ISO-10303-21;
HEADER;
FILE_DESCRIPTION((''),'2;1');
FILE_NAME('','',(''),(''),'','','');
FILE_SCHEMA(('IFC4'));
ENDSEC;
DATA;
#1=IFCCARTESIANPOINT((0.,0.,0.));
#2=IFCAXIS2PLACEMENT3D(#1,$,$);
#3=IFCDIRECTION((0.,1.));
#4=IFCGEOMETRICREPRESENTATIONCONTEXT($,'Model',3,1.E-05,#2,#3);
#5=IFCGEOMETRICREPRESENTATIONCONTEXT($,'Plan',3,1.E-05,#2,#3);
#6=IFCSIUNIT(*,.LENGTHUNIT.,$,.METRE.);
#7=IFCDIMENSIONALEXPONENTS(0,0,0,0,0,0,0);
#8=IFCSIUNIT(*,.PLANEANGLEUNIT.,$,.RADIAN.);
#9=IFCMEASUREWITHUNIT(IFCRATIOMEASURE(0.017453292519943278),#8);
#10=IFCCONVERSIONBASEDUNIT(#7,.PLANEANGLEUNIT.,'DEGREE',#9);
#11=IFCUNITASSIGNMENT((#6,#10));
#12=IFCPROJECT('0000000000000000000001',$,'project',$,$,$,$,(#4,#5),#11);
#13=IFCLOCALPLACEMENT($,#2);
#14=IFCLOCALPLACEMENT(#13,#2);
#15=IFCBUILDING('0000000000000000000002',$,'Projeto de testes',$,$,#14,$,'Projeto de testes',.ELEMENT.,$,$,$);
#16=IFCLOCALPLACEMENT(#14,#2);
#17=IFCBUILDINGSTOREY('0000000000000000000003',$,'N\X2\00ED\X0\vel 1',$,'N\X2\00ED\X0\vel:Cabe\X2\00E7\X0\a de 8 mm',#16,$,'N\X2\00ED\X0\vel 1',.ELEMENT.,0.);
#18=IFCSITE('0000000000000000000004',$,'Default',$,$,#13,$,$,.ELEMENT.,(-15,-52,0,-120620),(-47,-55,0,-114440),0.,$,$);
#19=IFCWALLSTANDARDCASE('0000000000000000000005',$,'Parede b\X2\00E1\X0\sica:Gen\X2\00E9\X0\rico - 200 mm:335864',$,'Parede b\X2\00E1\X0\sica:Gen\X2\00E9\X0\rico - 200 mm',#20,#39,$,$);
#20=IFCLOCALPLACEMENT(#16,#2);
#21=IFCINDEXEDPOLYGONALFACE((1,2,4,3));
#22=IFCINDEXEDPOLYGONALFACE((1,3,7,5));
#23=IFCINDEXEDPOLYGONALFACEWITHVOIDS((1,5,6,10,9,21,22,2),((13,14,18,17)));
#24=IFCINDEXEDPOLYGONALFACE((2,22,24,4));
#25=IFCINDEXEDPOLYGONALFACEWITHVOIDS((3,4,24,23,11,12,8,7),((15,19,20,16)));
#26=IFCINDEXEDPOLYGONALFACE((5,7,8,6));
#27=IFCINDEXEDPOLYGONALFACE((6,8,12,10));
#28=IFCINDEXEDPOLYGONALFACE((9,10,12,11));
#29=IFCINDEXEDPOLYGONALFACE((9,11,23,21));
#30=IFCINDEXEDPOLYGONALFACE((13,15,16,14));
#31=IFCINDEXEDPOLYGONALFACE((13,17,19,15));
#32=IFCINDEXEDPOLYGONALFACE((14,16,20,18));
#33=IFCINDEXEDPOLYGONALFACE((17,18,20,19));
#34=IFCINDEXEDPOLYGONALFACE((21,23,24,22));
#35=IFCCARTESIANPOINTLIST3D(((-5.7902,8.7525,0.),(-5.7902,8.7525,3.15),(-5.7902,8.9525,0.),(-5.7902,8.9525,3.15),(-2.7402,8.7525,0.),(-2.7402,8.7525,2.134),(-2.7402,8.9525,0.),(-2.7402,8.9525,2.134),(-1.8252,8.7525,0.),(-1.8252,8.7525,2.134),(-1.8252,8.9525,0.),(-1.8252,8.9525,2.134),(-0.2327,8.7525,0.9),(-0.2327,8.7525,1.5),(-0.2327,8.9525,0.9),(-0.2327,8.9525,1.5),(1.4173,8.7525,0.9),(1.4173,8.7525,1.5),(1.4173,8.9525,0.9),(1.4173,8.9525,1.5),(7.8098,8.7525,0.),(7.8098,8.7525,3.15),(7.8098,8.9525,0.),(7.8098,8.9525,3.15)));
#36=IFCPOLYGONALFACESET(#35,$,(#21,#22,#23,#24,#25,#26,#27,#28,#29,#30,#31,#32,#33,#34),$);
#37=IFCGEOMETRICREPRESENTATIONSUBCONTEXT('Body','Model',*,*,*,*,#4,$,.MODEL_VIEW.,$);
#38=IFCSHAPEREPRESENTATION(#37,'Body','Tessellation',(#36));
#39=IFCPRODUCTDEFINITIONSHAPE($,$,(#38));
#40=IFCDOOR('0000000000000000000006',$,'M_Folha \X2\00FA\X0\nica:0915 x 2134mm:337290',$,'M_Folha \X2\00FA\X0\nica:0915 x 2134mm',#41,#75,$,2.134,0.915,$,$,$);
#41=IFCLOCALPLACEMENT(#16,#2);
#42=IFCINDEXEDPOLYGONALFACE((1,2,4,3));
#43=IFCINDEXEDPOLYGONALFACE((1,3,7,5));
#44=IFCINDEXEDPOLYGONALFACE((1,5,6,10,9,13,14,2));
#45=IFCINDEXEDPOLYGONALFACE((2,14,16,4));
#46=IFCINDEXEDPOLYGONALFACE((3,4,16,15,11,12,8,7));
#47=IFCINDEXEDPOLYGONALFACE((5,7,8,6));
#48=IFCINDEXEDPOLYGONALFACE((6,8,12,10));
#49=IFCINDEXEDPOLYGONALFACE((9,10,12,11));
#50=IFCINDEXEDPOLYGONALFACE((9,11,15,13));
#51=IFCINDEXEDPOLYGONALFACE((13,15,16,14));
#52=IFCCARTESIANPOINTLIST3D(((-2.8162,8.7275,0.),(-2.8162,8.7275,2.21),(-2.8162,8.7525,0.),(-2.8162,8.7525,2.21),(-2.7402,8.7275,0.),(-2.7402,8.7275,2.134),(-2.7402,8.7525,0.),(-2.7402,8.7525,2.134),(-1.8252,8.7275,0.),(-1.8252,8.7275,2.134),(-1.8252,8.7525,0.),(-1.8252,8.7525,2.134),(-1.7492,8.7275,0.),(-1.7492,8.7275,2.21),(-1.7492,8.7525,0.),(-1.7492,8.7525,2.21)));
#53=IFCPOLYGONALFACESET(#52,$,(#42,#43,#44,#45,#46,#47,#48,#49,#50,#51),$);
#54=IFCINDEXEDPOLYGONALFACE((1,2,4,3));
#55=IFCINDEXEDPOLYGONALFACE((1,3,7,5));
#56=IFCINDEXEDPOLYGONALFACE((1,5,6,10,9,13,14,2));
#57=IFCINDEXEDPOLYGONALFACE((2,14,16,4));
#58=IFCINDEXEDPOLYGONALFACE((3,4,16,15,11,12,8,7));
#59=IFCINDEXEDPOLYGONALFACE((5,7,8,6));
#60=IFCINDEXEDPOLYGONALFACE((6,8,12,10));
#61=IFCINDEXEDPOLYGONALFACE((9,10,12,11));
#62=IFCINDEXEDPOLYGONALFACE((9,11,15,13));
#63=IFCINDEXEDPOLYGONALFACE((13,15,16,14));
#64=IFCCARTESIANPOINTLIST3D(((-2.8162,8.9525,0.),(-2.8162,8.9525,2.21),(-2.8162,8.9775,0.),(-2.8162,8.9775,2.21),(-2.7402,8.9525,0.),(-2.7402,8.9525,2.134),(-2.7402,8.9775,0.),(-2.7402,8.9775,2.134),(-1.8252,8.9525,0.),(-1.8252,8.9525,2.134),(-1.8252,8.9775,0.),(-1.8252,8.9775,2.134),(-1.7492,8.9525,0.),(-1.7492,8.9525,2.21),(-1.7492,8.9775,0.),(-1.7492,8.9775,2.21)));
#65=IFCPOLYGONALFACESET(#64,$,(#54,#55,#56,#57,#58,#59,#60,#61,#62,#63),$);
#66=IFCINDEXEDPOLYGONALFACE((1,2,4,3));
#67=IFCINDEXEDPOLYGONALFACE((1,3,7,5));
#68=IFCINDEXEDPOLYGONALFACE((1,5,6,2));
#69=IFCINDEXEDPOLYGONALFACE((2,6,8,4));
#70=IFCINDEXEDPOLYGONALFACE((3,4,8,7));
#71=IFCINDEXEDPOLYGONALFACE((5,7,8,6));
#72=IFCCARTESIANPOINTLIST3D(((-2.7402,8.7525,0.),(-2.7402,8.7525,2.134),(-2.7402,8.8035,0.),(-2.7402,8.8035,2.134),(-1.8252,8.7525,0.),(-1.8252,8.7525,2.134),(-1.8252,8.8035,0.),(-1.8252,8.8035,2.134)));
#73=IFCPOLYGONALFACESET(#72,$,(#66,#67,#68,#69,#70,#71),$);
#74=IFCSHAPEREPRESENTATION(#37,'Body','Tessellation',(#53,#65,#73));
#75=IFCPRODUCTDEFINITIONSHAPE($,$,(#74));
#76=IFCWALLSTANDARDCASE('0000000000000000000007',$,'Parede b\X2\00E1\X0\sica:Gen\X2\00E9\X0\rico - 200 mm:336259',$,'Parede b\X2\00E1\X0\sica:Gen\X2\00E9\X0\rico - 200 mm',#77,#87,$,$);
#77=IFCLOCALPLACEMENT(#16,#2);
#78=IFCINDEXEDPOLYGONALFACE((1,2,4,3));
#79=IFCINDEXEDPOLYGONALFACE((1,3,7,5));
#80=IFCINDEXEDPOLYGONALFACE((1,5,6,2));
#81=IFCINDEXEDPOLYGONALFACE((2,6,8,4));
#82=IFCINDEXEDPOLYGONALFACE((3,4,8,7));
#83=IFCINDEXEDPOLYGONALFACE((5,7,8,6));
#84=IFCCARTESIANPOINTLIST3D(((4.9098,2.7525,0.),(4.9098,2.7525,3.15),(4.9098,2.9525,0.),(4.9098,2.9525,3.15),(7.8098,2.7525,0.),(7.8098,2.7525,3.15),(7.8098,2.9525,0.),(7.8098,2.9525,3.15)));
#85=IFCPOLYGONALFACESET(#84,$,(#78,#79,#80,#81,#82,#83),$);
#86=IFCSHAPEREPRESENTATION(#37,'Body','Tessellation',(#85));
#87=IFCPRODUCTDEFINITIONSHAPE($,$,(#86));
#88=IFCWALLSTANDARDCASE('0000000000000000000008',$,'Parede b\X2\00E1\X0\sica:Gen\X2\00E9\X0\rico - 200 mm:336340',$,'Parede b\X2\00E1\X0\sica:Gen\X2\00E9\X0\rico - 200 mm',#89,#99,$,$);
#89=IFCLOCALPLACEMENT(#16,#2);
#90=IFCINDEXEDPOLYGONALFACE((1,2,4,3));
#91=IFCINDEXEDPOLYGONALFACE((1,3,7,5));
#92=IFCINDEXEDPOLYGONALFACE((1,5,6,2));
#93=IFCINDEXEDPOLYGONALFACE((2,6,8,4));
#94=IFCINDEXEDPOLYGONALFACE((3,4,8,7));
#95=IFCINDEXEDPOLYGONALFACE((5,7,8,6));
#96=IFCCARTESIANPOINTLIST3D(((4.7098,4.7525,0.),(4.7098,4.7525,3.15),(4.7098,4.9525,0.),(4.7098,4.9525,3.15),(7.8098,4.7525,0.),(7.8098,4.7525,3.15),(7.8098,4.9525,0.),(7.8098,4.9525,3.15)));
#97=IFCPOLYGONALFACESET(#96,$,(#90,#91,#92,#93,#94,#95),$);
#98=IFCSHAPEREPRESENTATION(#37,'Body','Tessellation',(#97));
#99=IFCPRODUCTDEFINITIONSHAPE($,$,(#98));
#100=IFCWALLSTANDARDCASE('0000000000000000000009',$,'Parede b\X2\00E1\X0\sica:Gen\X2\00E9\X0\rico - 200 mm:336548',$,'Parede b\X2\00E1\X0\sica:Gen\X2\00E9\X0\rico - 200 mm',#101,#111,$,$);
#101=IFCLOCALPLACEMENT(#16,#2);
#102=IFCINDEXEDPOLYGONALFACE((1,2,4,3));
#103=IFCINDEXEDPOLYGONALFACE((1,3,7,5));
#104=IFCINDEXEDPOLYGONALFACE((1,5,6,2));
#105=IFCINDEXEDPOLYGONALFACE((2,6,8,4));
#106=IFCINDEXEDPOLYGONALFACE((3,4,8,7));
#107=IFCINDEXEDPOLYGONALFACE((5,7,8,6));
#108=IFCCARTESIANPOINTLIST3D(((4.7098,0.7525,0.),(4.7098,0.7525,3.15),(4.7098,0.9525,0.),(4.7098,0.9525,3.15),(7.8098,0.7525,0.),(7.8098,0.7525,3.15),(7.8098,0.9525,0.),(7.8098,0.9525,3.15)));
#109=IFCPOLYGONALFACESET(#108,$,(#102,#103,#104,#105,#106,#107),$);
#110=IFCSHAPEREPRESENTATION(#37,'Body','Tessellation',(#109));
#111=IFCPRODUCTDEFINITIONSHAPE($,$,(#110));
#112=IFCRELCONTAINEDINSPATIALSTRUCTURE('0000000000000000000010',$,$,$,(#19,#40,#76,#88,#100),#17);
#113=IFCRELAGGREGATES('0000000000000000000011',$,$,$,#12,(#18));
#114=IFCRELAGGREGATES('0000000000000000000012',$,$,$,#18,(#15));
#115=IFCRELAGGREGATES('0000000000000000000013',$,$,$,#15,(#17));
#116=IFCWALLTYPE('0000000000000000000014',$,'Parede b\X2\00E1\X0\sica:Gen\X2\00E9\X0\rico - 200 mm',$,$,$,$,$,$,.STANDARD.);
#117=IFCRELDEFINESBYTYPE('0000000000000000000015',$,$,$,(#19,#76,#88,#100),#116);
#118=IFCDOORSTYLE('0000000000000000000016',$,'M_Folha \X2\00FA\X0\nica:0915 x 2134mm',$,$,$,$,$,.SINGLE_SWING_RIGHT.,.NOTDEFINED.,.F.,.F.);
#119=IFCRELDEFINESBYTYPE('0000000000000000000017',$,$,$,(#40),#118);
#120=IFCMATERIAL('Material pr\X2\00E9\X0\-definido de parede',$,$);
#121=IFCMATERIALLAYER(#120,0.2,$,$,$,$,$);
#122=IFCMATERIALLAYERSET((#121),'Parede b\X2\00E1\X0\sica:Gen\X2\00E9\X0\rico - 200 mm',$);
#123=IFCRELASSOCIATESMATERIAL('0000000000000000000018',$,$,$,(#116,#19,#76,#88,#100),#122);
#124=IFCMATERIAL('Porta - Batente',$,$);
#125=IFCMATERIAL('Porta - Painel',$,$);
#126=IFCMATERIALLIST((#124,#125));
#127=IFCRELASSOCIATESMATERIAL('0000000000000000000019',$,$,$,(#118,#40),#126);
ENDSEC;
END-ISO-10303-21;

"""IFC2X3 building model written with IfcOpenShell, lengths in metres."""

from ifc_helpers import new_model, entity, si_unit, converted_unit, direction, frame, frame_2d, origin, place, context, subcontext, project, spatial, polyline, rectangle, outline, extrude, source, transform, mapped, material, material_list, layer, layer_set, layer_usage, type_object, type_shapes, element, fill, save


model = new_model("IFC2X3")

# Units and contexts
model_context = context("Model", 3, precision=1e-05, world=origin(), true_north=direction((0.0, 1.0)))
plan_context = context("Plan", 3, precision=1e-05, world=origin(), true_north=direction((0.0, 1.0)))
body_context = subcontext(model_context, "Body", "Model", "MODEL_VIEW")
ifc_project = project(units=[si_unit("LENGTHUNIT", "METRE"), converted_unit("PLANEANGLEUNIT", "DEGREE", entity("IfcRatioMeasure", 0.017453292519943278), si_unit("PLANEANGLEUNIT", "RADIAN"), dimensions=[0, 0, 0, 0, 0, 0, 0])], contexts=[model_context, plan_context])

# Site, building, storey
site_placement = place(None, origin())
site = spatial("IfcSite", under=ifc_project, at=site_placement, Name="Default", CompositionType="ELEMENT", RefLatitude=(-15, -52, 0, -120620), RefLongitude=(-47, -55, 0, -114440), RefElevation=0.0)
building_placement = place(site_placement, origin())
building = spatial("IfcBuilding", under=site, at=building_placement, Name="Projeto de testes", LongName="Projeto de testes", CompositionType="ELEMENT")
storey_placement = place(building_placement, origin())
storey = spatial("IfcBuildingStorey", under=building, at=storey_placement, Name="Nível 1", ObjectType="Nível:Cabeça de 8 mm", LongName="Nível 1", CompositionType="ELEMENT", Elevation=0.0)

# Shared definitions
ifc_material_1 = material(Name="Material pré-definido de parede")
ifc_layer = layer(ifc_material_1, 0.2)
ifc_layer_set = layer_set([ifc_layer], Name="Parede básica:Genérico - 200 mm")
ifc_layer_usage_1 = layer_usage(ifc_layer_set, "AXIS2", "POSITIVE", -0.1)
wall_type = type_object("IfcWallType", Name="Parede básica:Genérico - 200 mm", PredefinedType="STANDARD", material=ifc_layer_set)

# Wall, openings, door
wall_1_placement = place(storey_placement, frame((7.8098, 8.8525, 0.0), z_axis=(0.0, 0.0, 1.0), x_axis=(-1.0, 0.0, 0.0)))
wall_1 = element("IfcWallStandardCase", 1, at=wall_1_placement, inside=storey, type_object=wall_type, material=ifc_layer_usage_1, Name="Parede básica:Genérico - 200 mm:335864", ObjectType="Parede básica:Genérico - 200 mm", context=body_context, shape_type="SweptSolid", body=[
    extrude(rectangle(XDim=13.6, YDim=0.2, at=frame_2d((6.8, 0.0), x_axis=(-1.0, 0.0))), origin(), (0.0, 0.0, 1.0), 3.15),
])
opening_1_placement = place(wall_1_placement, frame((9.635, -0.1, 0.0)))
opening_1 = element("IfcOpeningElement", 2, at=opening_1_placement, cuts=wall_1, ObjectType="Opening", context=body_context, shape_type="SweptSolid", body=[
    extrude(rectangle(XDim=0.915, YDim=2.134, at=frame_2d((1.067, 0.4575), x_axis=(0.0, 1.0))), frame((0.0, 0.0, 0.0), z_axis=(0.0, 1.0, 0.0), x_axis=(0.0, 0.0, 1.0)), (0.0, 0.0, 1.0), 0.2),
])
opening_2_placement = place(wall_1_placement, frame((8.0425, 0.1, 0.9)))
element("IfcOpeningElement", 3, at=opening_2_placement, cuts=wall_1, ObjectType="Opening", context=body_context, shape_type="SweptSolid", body=[
    extrude(rectangle(XDim=0.6, YDim=1.65, at=frame_2d((0.3, 0.825), x_axis=(-1.0, 0.0))), frame((0.0, 0.0, 0.0), z_axis=(0.0, -1.0, 0.0), x_axis=(0.0, 0.0, 1.0)), (0.0, 0.0, 1.0), 0.2),
])
ifc_material_2 = material(Name="Porta - Batente")
ifc_material_3 = material(Name="Porta - Painel")
ifc_material_list_1 = material_list([ifc_material_2, ifc_material_3])
door_style_1 = type_object("IfcDoorStyle", Name="M_Folha única:0915 x 2134mm", ConstructionType="NOTDEFINED", OperationType="SINGLE_SWING_RIGHT", ParameterTakesPrecedence=False, Sizeable=False, material=ifc_material_list_1)
shared_shape_1 = source(origin(), body_context, "Body", "SweptSolid", [
    extrude(outline(polyline([(-0.5335, -1.124), (0.5335, -1.124), (0.5335, 1.086), (0.4575, 1.086), (0.4575, -1.048), (-0.4575, -1.048), (-0.4575, 1.086), (-0.5335, 1.086), (-0.5335, -1.124)])), frame((0.4575, 0.2, 1.086), z_axis=(0.0, 1.0, 0.0), x_axis=(1.0, 0.0, 0.0)), (0.0, 0.0, 1.0), 0.025),
    extrude(outline(polyline([(-1.124, -0.5335), (1.086, -0.5335), (1.086, -0.4575), (-1.048, -0.4575), (-1.048, 0.4575), (1.086, 0.4575), (1.086, 0.5335), (-1.124, 0.5335), (-1.124, -0.5335)])), frame((0.4575, -0.025, 1.086), z_axis=(0.0, 1.0, 0.0), x_axis=(0.0, 0.0, -1.0)), (0.0, 0.0, 1.0), 0.025),
    extrude(rectangle(XDim=0.051, YDim=0.915, at=frame_2d((0.0, 0.0), x_axis=(1.0, 0.0))), frame((0.4575, 0.1745, 0.0), z_axis=(0.0, 0.0, 1.0), x_axis=(0.0, 1.0, 0.0)), (0.0, 0.0, 1.0), 2.134),
])
type_shapes(door_style_1, [shared_shape_1])
door_1_placement = place(opening_1_placement, origin())
door_1 = element("IfcDoor", 4, at=door_1_placement, inside=storey, type_object=door_style_1, material=ifc_material_list_1, Name="M_Folha única:0915 x 2134mm:337290", ObjectType="M_Folha única:0915 x 2134mm", OverallHeight=2.134, OverallWidth=0.915, context=body_context, shape_type="MappedRepresentation", body=[
    mapped(shared_shape_1, transform((0.0, 0.0, 0.0), scale=1.0)),
])
fill(opening_1, door_1)

# Walls
ifc_layer_usage_2 = layer_usage(ifc_layer_set, "AXIS2", "NEGATIVE", 0.1)
wall_2_placement = place(storey_placement, frame((7.8098, 2.8525, 0.0), z_axis=(0.0, 0.0, 1.0), x_axis=(-1.0, 0.0, 0.0)))
element("IfcWallStandardCase", 5, at=wall_2_placement, inside=storey, type_object=wall_type, material=ifc_layer_usage_2, Name="Parede básica:Genérico - 200 mm:336259", ObjectType="Parede básica:Genérico - 200 mm", context=body_context, shape_type="SweptSolid", body=[
    extrude(rectangle(XDim=2.9, YDim=0.2, at=frame_2d((1.45, 0.0), x_axis=(-1.0, 0.0))), origin(), (0.0, 0.0, 1.0), 3.15),
])
wall_3_placement = place(storey_placement, frame((7.8098, 4.8525, 0.0), z_axis=(0.0, 0.0, 1.0), x_axis=(-1.0, 0.0, 0.0)))
element("IfcWallStandardCase", 6, at=wall_3_placement, inside=storey, type_object=wall_type, material=ifc_layer_usage_2, Name="Parede básica:Genérico - 200 mm:336340", ObjectType="Parede básica:Genérico - 200 mm", context=body_context, shape_type="SweptSolid", body=[
    extrude(rectangle(XDim=3.1, YDim=0.2, at=frame_2d((1.55, 0.0), x_axis=(-1.0, 0.0))), origin(), (0.0, 0.0, 1.0), 3.15),
])
wall_4_placement = place(storey_placement, frame((7.8098, 0.8525, 0.0), z_axis=(0.0, 0.0, 1.0), x_axis=(-1.0, 0.0, 0.0)))
element("IfcWallStandardCase", 7, at=wall_4_placement, inside=storey, type_object=wall_type, material=ifc_layer_usage_2, Name="Parede básica:Genérico - 200 mm:336548", ObjectType="Parede básica:Genérico - 200 mm", context=body_context, shape_type="SweptSolid", body=[
    extrude(rectangle(XDim=3.1, YDim=0.2, at=frame_2d((1.55, 0.0), x_axis=(-1.0, 0.0))), origin(), (0.0, 0.0, 1.0), 3.15),
])

save(model, "model.ifc")
